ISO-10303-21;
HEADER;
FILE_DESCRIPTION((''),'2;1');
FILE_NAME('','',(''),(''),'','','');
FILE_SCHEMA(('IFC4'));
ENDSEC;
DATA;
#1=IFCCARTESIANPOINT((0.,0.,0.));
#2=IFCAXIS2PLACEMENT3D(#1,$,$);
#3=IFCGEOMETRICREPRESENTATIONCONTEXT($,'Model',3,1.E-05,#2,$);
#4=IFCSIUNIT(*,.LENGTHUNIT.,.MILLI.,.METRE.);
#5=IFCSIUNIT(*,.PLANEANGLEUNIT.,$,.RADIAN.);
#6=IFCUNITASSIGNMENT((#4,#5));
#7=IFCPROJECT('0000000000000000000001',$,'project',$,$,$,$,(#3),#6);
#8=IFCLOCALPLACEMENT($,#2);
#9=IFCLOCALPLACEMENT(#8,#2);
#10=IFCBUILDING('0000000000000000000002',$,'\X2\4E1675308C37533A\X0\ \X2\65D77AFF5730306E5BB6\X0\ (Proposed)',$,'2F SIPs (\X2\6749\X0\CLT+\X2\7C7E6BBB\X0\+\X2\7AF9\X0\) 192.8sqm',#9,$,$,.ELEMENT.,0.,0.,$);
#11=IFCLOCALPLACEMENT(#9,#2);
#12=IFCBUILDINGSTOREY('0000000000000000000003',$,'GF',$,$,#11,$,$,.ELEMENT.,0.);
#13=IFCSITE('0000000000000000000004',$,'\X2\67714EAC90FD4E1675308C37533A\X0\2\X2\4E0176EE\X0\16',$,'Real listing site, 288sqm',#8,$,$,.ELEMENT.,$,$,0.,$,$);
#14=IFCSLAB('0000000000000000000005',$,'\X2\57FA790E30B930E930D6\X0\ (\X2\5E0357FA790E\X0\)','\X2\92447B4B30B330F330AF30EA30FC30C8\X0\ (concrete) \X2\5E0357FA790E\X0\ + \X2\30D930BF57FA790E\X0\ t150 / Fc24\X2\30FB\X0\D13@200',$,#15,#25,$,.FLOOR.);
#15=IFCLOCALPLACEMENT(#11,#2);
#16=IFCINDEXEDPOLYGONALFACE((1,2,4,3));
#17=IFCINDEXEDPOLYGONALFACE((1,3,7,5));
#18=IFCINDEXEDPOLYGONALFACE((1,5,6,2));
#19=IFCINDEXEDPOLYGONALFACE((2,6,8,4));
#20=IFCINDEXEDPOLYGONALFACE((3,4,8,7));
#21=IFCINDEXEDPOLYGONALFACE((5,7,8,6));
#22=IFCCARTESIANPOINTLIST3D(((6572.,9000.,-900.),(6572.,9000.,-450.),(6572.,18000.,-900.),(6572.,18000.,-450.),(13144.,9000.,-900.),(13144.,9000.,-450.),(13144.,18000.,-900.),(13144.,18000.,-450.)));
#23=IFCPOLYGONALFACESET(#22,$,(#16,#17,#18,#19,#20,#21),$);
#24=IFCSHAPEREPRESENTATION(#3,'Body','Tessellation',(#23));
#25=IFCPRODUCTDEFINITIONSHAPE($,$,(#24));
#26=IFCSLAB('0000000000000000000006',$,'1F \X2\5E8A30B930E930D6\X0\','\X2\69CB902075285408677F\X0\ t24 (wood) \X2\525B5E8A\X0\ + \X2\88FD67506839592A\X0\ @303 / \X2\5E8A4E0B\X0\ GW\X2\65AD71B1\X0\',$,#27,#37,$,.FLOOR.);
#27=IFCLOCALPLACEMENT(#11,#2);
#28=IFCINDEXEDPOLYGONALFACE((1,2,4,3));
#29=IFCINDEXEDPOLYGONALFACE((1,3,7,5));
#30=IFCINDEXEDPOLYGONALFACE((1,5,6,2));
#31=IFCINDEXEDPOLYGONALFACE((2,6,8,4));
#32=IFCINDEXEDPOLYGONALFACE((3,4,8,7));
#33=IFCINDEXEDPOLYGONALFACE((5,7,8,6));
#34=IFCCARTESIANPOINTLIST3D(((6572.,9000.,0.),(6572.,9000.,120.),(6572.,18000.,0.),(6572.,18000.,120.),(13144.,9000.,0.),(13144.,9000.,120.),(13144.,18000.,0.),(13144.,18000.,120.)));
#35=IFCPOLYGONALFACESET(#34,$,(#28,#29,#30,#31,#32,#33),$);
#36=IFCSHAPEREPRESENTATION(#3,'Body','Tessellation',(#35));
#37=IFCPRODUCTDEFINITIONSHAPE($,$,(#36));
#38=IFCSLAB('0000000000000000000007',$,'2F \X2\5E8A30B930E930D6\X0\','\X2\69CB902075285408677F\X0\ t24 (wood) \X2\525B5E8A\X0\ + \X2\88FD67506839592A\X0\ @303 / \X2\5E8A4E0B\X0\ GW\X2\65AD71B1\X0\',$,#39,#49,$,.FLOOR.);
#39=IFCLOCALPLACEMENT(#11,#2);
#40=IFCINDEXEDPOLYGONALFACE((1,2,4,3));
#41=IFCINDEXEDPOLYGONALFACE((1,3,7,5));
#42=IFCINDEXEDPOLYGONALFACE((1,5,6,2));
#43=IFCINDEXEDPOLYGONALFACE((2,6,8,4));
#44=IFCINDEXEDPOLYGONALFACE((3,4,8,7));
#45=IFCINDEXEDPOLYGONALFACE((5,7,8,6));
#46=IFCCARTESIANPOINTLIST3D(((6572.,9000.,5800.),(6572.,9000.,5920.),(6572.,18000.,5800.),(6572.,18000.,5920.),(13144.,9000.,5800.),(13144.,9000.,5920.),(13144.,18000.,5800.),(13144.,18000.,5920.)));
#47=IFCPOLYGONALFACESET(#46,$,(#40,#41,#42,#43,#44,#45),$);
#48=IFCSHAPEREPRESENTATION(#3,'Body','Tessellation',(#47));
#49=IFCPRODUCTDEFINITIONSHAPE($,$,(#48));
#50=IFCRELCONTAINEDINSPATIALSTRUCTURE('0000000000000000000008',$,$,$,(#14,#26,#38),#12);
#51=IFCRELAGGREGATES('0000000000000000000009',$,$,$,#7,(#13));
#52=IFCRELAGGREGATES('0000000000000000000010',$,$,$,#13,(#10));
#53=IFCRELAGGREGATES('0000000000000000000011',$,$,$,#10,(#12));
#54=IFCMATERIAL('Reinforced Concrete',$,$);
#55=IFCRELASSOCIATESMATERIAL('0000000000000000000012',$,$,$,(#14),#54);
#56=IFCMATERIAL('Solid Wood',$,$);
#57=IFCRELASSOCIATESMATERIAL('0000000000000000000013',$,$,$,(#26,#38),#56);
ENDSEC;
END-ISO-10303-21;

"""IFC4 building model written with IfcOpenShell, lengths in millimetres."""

from ifc_helpers import new_model, si_unit, frame, frame_2d, origin, place, context, project, spatial, rectangle, extrude, material, element, save


model = new_model("IFC4")

# Units and contexts
model_context = context("Model", 3, precision=1e-05, world=origin())
ifc_project = project(units=[si_unit("LENGTHUNIT", "METRE", prefix="MILLI"), si_unit("PLANEANGLEUNIT", "RADIAN")], contexts=[model_context])

# Site, building, storey
site_placement = place(None, origin())
site = spatial("IfcSite", under=ifc_project, at=site_placement, Name="東京都世田谷区2丁目16", ObjectType="Real listing site, 288sqm", CompositionType="ELEMENT", RefElevation=0.0)
building_placement = place(site_placement, origin())
building = spatial("IfcBuilding", under=site, at=building_placement, Name="世田谷区 旗竿地の家 (Proposed)", ObjectType="2F SIPs (杉CLT+籾殻+竹) 192.8sqm", CompositionType="ELEMENT", ElevationOfRefHeight=0.0, ElevationOfTerrain=0.0)
storey_placement = place(building_placement, origin())
storey = spatial("IfcBuildingStorey", under=building, at=storey_placement, Name="GF", CompositionType="ELEMENT", Elevation=0.0)

# Slabs
ifc_material_1 = material(Name="Reinforced Concrete")
slab_1_placement = place(storey_placement, frame((3286.0, 4500.0, -450.0)))
element("IfcSlab", 1, at=slab_1_placement, inside=storey, material=ifc_material_1, Name="基礎スラブ (布基礎)", Description="鉄筋コンクリート (concrete) 布基礎 + ベタ基礎 t150 / Fc24・D13@200", PredefinedType="FLOOR", context=model_context, shape_type="SweptSolid", body=[
    extrude(rectangle(XDim=6572.0, YDim=9000.0, at=frame_2d((3286.0, 4500.0))), frame((3286.0, 4500.0, -450.0)), (0.0, 0.0, 1.0), 450.0),
])
ifc_material_2 = material(Name="Solid Wood")
slab_2_placement = place(storey_placement, frame((3286.0, 4500.0, 0.0)))
element("IfcSlab", 2, at=slab_2_placement, inside=storey, material=ifc_material_2, Name="1F 床スラブ", Description="構造用合板 t24 (wood) 剛床 + 製材根太 @303 / 床下 GW断熱", PredefinedType="FLOOR", context=model_context, shape_type="SweptSolid", body=[
    extrude(rectangle(XDim=6572.0, YDim=9000.0, at=frame_2d((3286.0, 4500.0))), frame((3286.0, 4500.0, 0.0)), (0.0, 0.0, 1.0), 120.0),
])
slab_3_placement = place(storey_placement, frame((3286.0, 4500.0, 2900.0)))
element("IfcSlab", 3, at=slab_3_placement, inside=storey, material=ifc_material_2, Name="2F 床スラブ", Description="構造用合板 t24 (wood) 剛床 + 製材根太 @303 / 床下 GW断熱", PredefinedType="FLOOR", context=model_context, shape_type="SweptSolid", body=[
    extrude(rectangle(XDim=6572.0, YDim=9000.0, at=frame_2d((3286.0, 4500.0))), frame((3286.0, 4500.0, 2900.0)), (0.0, 0.0, 1.0), 120.0),
])

save(model, "model.ifc")
